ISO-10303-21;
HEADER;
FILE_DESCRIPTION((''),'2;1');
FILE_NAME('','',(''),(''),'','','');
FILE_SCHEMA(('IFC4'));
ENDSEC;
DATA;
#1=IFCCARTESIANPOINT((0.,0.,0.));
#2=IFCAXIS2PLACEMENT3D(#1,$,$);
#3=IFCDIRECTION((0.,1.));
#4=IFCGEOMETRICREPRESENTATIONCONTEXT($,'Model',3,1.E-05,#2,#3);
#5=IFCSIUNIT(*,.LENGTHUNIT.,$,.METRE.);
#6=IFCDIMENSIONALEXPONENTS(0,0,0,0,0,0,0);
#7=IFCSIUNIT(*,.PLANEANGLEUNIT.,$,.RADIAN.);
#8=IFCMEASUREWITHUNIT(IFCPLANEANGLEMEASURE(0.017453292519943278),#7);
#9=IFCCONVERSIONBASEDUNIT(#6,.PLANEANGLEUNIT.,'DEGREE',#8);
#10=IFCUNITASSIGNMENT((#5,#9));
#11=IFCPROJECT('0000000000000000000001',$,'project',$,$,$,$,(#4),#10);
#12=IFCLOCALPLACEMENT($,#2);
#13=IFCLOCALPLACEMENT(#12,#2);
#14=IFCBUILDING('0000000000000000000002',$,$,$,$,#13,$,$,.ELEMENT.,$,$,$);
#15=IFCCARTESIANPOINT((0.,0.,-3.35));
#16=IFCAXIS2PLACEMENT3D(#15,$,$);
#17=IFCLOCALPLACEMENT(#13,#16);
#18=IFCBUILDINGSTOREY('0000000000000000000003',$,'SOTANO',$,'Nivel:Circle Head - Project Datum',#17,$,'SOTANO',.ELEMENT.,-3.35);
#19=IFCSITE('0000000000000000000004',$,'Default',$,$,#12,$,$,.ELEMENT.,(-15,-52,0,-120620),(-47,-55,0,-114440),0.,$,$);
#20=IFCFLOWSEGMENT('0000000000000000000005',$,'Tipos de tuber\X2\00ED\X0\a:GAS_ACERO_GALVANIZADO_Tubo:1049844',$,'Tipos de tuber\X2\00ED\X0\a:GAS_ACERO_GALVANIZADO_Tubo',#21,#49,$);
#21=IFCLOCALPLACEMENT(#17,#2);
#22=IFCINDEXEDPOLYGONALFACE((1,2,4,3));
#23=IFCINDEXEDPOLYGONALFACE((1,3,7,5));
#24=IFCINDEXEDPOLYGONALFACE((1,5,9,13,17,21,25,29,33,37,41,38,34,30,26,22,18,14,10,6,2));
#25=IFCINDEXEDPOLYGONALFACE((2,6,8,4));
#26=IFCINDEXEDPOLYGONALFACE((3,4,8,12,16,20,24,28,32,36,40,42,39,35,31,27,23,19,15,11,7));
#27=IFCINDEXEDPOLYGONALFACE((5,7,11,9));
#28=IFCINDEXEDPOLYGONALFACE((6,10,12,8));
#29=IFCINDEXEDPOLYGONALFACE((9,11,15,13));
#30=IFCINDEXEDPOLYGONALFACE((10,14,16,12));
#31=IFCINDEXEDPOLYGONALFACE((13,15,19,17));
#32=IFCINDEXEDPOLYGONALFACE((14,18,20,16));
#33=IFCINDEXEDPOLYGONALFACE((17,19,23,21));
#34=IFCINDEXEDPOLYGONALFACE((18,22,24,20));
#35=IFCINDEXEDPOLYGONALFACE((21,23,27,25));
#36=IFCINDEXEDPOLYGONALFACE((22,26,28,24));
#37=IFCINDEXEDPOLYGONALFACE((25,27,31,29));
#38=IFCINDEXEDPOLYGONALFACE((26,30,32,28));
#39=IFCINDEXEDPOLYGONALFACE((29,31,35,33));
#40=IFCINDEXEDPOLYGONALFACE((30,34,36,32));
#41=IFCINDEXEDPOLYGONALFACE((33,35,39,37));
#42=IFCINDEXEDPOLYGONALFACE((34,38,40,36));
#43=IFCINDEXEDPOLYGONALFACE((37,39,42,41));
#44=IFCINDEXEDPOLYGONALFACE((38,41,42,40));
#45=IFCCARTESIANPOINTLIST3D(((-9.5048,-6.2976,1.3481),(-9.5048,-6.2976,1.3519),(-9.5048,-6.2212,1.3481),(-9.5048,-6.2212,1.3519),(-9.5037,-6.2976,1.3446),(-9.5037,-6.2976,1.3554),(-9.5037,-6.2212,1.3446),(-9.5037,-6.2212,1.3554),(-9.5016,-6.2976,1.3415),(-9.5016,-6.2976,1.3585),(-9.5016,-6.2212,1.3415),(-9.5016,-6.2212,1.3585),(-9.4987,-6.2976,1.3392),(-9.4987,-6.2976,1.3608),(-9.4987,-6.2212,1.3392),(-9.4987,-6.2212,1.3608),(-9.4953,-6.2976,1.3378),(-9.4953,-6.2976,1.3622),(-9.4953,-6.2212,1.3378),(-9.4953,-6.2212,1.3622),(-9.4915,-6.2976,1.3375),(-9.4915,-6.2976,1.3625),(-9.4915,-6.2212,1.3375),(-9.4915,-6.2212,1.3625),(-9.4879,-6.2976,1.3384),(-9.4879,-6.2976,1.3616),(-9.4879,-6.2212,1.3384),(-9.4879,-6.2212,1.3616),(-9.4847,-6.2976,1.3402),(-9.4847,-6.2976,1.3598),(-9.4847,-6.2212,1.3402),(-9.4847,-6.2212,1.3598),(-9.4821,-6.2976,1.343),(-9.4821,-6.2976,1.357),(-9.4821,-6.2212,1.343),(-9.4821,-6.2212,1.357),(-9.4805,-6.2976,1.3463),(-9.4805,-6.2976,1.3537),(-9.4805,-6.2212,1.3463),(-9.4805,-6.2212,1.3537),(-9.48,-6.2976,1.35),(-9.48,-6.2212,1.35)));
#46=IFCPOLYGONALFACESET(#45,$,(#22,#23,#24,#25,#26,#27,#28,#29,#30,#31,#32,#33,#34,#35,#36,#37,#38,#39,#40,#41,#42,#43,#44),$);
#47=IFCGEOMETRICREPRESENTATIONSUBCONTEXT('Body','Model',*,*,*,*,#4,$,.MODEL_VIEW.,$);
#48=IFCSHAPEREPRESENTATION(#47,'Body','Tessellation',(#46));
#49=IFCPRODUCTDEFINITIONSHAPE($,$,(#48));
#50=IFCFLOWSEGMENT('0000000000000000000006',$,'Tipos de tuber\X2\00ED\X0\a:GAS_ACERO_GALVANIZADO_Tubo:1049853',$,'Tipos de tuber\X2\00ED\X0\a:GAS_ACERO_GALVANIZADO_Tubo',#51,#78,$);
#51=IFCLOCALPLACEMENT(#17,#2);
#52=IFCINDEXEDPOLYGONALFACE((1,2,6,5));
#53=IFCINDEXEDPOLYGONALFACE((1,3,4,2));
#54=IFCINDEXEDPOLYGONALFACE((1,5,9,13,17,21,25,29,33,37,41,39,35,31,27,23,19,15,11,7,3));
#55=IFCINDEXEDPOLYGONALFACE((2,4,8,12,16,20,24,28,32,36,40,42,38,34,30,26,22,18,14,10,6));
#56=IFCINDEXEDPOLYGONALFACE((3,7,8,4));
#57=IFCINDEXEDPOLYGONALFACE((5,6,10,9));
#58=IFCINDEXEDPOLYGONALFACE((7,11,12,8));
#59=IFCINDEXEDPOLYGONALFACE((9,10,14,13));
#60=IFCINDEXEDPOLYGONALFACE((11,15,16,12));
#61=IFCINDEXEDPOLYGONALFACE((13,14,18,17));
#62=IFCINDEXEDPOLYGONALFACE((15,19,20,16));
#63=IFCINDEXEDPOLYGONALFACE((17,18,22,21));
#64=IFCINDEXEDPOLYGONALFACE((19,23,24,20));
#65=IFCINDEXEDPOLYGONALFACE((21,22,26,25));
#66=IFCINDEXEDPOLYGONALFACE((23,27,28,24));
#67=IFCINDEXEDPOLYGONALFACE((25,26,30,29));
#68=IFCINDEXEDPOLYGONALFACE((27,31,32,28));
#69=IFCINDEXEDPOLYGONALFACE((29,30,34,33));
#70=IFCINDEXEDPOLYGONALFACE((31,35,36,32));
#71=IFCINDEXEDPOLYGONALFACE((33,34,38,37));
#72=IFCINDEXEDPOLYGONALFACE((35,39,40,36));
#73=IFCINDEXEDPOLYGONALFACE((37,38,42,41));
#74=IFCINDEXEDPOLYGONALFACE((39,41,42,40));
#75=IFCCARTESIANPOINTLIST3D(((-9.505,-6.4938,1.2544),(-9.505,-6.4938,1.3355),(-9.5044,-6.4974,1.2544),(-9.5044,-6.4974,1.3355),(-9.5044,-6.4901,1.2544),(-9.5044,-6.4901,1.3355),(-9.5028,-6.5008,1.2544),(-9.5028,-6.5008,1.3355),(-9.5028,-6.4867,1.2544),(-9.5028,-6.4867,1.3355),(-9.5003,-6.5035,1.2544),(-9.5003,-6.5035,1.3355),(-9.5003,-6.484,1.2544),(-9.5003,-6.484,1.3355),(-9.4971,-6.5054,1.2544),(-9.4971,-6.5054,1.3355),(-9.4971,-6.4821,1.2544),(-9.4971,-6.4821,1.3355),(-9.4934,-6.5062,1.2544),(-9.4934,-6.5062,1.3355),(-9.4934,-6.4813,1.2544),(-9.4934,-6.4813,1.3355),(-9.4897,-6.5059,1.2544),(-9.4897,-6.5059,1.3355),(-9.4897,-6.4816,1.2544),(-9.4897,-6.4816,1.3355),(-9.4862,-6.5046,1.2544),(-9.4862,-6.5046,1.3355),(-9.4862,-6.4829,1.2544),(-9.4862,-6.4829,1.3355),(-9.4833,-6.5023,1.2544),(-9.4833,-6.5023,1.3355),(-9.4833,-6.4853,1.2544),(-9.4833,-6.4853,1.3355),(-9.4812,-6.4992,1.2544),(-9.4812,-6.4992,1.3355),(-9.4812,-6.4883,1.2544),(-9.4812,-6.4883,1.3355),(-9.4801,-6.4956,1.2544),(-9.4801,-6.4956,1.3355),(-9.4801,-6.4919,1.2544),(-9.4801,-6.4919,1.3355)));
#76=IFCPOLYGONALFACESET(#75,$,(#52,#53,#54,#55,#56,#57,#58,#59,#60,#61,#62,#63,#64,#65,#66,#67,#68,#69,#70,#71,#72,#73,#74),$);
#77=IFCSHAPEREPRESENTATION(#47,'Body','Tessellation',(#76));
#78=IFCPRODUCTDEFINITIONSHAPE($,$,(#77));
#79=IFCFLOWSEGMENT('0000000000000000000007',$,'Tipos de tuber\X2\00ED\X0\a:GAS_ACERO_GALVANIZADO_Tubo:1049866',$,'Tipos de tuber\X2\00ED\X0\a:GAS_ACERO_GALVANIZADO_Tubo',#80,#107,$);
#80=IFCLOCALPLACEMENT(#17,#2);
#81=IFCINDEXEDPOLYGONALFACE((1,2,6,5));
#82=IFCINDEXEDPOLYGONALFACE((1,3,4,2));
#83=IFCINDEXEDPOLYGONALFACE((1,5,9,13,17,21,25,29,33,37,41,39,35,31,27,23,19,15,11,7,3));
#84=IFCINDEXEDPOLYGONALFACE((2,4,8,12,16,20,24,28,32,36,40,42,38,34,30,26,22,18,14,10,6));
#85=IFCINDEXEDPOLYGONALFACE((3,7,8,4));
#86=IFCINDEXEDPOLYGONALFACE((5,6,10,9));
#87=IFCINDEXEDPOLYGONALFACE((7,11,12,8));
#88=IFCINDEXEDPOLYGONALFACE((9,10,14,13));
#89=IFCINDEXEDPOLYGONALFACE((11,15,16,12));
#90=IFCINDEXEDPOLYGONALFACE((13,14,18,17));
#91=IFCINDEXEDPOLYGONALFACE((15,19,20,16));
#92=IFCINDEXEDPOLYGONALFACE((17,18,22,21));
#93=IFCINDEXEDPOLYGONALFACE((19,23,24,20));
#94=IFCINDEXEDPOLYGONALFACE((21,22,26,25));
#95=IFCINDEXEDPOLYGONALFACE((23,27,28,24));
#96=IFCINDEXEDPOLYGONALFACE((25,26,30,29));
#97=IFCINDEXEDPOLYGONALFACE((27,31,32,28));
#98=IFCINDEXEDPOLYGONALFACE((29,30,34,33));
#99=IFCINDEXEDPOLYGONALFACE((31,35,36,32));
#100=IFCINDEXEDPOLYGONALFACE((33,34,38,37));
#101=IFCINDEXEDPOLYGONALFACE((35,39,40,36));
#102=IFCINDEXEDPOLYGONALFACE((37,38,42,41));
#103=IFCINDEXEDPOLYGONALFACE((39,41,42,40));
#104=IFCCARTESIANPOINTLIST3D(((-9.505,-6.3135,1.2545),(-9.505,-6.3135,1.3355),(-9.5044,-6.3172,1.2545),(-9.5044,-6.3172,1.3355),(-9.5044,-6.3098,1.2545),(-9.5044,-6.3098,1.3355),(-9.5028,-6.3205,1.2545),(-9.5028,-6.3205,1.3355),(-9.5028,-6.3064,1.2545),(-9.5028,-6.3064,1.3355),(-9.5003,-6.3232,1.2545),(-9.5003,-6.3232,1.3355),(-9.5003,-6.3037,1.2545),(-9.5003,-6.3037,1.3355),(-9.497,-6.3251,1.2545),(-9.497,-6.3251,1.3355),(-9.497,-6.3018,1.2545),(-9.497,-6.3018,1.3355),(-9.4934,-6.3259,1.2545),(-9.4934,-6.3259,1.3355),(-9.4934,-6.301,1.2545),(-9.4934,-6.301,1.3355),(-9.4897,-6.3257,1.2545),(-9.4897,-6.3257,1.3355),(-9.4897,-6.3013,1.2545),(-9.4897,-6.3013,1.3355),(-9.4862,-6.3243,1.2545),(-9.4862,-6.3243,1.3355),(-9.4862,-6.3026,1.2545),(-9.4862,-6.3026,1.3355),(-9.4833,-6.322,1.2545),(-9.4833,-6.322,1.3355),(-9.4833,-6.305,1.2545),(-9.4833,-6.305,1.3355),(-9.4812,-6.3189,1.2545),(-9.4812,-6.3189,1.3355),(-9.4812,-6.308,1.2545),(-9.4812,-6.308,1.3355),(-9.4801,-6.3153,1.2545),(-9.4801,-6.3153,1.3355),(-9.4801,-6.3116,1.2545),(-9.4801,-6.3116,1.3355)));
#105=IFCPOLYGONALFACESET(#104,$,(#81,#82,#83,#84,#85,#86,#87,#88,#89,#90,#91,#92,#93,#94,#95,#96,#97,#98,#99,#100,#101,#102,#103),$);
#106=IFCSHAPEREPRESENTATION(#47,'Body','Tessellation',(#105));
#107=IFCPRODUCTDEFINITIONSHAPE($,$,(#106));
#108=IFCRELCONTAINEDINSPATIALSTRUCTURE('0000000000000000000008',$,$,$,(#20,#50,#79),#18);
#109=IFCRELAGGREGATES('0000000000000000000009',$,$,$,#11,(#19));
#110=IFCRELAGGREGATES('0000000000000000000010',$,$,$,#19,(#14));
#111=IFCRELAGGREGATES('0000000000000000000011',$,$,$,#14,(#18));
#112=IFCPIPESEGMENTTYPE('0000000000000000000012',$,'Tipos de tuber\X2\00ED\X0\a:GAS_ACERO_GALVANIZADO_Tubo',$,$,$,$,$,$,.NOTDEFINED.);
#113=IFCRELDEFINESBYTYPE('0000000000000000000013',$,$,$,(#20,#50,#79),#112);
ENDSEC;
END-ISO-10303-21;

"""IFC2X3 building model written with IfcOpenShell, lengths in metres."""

from ifc_helpers import new_model, entity, si_unit, converted_unit, direction, frame, frame_2d, origin, origin_2d_with_axis, place, context, subcontext, project, spatial, circle, extrude, type_object, element, save


model = new_model("IFC2X3")

# Units and contexts
model_context = context("Model", 3, precision=1e-05, world=origin(), true_north=direction((0.0, 1.0)))
body_context = subcontext(model_context, "Body", "Model", "MODEL_VIEW")
ifc_project = project(units=[si_unit("LENGTHUNIT", "METRE"), converted_unit("PLANEANGLEUNIT", "DEGREE", entity("IfcPlaneAngleMeasure", 0.017453292519943278), si_unit("PLANEANGLEUNIT", "RADIAN"), dimensions=[0, 0, 0, 0, 0, 0, 0])], contexts=[model_context])

# Site, building, storey
site_placement = place(None, origin())
site = spatial("IfcSite", under=ifc_project, at=site_placement, Name="Default", CompositionType="ELEMENT", RefLatitude=(-15, -52, 0, -120620), RefLongitude=(-47, -55, 0, -114440), RefElevation=0.0)
building_placement = place(site_placement, origin())
building = spatial("IfcBuilding", under=site, at=building_placement, CompositionType="ELEMENT")
storey_placement = place(building_placement, frame((0.0, 0.0, -3.35)))
storey = spatial("IfcBuildingStorey", under=building, at=storey_placement, Name="SOTANO", ObjectType="Nivel:Circle Head - Project Datum", LongName="SOTANO", CompositionType="ELEMENT", Elevation=-3.35)

# Flow segments
pipe_segment_type_1 = type_object("IfcPipeSegmentType", Name="Tipos de tubería:GAS_ACERO_GALVANIZADO_Tubo", PredefinedType="NOTDEFINED")
flow_segment_1_placement = place(storey_placement, origin())
element("IfcFlowSegment", 1, at=flow_segment_1_placement, inside=storey, type_object=pipe_segment_type_1, Name="Tipos de tubería:GAS_ACERO_GALVANIZADO_Tubo:1049844", ObjectType="Tipos de tubería:GAS_ACERO_GALVANIZADO_Tubo", context=body_context, shape_type="SweptSolid", body=[
    extrude(circle(Radius=0.0125, at=origin_2d_with_axis()), frame((-9.4925, -6.2976, 1.35), z_axis=(0.000006, 1.0, 0.0), x_axis=(1.0, -0.000006, 0.0)), (0.0, 0.0, 1.0), 0.0763),
])
flow_segment_2_placement = place(storey_placement, origin())
element("IfcFlowSegment", 2, at=flow_segment_2_placement, inside=storey, type_object=pipe_segment_type_1, Name="Tipos de tubería:GAS_ACERO_GALVANIZADO_Tubo:1049853", ObjectType="Tipos de tubería:GAS_ACERO_GALVANIZADO_Tubo", context=body_context, shape_type="SweptSolid", body=[
    extrude(circle(Radius=0.0125, at=frame_2d((0.0, 0.0), x_axis=(1.0, 0.0))), frame((-9.4925, -6.4938, 1.2544), z_axis=(0.000013, 0.0, 1.0), x_axis=(-1.0, 0.0, 0.000013)), (0.0, 0.0, 1.0), 0.0811),
])
flow_segment_3_placement = place(storey_placement, origin())
element("IfcFlowSegment", 3, at=flow_segment_3_placement, inside=storey, type_object=pipe_segment_type_1, Name="Tipos de tubería:GAS_ACERO_GALVANIZADO_Tubo:1049866", ObjectType="Tipos de tubería:GAS_ACERO_GALVANIZADO_Tubo", context=body_context, shape_type="SweptSolid", body=[
    extrude(circle(Radius=0.0125, at=frame_2d((0.0, 0.0), x_axis=(1.0, 0.0))), frame((-9.4925, -6.3135, 1.2545), z_axis=(-0.000037, 0.0, 1.0), x_axis=(-1.0, 0.0, -0.000037)), (0.0, 0.0, 1.0), 0.081),
])

save(model, "model.ifc")
